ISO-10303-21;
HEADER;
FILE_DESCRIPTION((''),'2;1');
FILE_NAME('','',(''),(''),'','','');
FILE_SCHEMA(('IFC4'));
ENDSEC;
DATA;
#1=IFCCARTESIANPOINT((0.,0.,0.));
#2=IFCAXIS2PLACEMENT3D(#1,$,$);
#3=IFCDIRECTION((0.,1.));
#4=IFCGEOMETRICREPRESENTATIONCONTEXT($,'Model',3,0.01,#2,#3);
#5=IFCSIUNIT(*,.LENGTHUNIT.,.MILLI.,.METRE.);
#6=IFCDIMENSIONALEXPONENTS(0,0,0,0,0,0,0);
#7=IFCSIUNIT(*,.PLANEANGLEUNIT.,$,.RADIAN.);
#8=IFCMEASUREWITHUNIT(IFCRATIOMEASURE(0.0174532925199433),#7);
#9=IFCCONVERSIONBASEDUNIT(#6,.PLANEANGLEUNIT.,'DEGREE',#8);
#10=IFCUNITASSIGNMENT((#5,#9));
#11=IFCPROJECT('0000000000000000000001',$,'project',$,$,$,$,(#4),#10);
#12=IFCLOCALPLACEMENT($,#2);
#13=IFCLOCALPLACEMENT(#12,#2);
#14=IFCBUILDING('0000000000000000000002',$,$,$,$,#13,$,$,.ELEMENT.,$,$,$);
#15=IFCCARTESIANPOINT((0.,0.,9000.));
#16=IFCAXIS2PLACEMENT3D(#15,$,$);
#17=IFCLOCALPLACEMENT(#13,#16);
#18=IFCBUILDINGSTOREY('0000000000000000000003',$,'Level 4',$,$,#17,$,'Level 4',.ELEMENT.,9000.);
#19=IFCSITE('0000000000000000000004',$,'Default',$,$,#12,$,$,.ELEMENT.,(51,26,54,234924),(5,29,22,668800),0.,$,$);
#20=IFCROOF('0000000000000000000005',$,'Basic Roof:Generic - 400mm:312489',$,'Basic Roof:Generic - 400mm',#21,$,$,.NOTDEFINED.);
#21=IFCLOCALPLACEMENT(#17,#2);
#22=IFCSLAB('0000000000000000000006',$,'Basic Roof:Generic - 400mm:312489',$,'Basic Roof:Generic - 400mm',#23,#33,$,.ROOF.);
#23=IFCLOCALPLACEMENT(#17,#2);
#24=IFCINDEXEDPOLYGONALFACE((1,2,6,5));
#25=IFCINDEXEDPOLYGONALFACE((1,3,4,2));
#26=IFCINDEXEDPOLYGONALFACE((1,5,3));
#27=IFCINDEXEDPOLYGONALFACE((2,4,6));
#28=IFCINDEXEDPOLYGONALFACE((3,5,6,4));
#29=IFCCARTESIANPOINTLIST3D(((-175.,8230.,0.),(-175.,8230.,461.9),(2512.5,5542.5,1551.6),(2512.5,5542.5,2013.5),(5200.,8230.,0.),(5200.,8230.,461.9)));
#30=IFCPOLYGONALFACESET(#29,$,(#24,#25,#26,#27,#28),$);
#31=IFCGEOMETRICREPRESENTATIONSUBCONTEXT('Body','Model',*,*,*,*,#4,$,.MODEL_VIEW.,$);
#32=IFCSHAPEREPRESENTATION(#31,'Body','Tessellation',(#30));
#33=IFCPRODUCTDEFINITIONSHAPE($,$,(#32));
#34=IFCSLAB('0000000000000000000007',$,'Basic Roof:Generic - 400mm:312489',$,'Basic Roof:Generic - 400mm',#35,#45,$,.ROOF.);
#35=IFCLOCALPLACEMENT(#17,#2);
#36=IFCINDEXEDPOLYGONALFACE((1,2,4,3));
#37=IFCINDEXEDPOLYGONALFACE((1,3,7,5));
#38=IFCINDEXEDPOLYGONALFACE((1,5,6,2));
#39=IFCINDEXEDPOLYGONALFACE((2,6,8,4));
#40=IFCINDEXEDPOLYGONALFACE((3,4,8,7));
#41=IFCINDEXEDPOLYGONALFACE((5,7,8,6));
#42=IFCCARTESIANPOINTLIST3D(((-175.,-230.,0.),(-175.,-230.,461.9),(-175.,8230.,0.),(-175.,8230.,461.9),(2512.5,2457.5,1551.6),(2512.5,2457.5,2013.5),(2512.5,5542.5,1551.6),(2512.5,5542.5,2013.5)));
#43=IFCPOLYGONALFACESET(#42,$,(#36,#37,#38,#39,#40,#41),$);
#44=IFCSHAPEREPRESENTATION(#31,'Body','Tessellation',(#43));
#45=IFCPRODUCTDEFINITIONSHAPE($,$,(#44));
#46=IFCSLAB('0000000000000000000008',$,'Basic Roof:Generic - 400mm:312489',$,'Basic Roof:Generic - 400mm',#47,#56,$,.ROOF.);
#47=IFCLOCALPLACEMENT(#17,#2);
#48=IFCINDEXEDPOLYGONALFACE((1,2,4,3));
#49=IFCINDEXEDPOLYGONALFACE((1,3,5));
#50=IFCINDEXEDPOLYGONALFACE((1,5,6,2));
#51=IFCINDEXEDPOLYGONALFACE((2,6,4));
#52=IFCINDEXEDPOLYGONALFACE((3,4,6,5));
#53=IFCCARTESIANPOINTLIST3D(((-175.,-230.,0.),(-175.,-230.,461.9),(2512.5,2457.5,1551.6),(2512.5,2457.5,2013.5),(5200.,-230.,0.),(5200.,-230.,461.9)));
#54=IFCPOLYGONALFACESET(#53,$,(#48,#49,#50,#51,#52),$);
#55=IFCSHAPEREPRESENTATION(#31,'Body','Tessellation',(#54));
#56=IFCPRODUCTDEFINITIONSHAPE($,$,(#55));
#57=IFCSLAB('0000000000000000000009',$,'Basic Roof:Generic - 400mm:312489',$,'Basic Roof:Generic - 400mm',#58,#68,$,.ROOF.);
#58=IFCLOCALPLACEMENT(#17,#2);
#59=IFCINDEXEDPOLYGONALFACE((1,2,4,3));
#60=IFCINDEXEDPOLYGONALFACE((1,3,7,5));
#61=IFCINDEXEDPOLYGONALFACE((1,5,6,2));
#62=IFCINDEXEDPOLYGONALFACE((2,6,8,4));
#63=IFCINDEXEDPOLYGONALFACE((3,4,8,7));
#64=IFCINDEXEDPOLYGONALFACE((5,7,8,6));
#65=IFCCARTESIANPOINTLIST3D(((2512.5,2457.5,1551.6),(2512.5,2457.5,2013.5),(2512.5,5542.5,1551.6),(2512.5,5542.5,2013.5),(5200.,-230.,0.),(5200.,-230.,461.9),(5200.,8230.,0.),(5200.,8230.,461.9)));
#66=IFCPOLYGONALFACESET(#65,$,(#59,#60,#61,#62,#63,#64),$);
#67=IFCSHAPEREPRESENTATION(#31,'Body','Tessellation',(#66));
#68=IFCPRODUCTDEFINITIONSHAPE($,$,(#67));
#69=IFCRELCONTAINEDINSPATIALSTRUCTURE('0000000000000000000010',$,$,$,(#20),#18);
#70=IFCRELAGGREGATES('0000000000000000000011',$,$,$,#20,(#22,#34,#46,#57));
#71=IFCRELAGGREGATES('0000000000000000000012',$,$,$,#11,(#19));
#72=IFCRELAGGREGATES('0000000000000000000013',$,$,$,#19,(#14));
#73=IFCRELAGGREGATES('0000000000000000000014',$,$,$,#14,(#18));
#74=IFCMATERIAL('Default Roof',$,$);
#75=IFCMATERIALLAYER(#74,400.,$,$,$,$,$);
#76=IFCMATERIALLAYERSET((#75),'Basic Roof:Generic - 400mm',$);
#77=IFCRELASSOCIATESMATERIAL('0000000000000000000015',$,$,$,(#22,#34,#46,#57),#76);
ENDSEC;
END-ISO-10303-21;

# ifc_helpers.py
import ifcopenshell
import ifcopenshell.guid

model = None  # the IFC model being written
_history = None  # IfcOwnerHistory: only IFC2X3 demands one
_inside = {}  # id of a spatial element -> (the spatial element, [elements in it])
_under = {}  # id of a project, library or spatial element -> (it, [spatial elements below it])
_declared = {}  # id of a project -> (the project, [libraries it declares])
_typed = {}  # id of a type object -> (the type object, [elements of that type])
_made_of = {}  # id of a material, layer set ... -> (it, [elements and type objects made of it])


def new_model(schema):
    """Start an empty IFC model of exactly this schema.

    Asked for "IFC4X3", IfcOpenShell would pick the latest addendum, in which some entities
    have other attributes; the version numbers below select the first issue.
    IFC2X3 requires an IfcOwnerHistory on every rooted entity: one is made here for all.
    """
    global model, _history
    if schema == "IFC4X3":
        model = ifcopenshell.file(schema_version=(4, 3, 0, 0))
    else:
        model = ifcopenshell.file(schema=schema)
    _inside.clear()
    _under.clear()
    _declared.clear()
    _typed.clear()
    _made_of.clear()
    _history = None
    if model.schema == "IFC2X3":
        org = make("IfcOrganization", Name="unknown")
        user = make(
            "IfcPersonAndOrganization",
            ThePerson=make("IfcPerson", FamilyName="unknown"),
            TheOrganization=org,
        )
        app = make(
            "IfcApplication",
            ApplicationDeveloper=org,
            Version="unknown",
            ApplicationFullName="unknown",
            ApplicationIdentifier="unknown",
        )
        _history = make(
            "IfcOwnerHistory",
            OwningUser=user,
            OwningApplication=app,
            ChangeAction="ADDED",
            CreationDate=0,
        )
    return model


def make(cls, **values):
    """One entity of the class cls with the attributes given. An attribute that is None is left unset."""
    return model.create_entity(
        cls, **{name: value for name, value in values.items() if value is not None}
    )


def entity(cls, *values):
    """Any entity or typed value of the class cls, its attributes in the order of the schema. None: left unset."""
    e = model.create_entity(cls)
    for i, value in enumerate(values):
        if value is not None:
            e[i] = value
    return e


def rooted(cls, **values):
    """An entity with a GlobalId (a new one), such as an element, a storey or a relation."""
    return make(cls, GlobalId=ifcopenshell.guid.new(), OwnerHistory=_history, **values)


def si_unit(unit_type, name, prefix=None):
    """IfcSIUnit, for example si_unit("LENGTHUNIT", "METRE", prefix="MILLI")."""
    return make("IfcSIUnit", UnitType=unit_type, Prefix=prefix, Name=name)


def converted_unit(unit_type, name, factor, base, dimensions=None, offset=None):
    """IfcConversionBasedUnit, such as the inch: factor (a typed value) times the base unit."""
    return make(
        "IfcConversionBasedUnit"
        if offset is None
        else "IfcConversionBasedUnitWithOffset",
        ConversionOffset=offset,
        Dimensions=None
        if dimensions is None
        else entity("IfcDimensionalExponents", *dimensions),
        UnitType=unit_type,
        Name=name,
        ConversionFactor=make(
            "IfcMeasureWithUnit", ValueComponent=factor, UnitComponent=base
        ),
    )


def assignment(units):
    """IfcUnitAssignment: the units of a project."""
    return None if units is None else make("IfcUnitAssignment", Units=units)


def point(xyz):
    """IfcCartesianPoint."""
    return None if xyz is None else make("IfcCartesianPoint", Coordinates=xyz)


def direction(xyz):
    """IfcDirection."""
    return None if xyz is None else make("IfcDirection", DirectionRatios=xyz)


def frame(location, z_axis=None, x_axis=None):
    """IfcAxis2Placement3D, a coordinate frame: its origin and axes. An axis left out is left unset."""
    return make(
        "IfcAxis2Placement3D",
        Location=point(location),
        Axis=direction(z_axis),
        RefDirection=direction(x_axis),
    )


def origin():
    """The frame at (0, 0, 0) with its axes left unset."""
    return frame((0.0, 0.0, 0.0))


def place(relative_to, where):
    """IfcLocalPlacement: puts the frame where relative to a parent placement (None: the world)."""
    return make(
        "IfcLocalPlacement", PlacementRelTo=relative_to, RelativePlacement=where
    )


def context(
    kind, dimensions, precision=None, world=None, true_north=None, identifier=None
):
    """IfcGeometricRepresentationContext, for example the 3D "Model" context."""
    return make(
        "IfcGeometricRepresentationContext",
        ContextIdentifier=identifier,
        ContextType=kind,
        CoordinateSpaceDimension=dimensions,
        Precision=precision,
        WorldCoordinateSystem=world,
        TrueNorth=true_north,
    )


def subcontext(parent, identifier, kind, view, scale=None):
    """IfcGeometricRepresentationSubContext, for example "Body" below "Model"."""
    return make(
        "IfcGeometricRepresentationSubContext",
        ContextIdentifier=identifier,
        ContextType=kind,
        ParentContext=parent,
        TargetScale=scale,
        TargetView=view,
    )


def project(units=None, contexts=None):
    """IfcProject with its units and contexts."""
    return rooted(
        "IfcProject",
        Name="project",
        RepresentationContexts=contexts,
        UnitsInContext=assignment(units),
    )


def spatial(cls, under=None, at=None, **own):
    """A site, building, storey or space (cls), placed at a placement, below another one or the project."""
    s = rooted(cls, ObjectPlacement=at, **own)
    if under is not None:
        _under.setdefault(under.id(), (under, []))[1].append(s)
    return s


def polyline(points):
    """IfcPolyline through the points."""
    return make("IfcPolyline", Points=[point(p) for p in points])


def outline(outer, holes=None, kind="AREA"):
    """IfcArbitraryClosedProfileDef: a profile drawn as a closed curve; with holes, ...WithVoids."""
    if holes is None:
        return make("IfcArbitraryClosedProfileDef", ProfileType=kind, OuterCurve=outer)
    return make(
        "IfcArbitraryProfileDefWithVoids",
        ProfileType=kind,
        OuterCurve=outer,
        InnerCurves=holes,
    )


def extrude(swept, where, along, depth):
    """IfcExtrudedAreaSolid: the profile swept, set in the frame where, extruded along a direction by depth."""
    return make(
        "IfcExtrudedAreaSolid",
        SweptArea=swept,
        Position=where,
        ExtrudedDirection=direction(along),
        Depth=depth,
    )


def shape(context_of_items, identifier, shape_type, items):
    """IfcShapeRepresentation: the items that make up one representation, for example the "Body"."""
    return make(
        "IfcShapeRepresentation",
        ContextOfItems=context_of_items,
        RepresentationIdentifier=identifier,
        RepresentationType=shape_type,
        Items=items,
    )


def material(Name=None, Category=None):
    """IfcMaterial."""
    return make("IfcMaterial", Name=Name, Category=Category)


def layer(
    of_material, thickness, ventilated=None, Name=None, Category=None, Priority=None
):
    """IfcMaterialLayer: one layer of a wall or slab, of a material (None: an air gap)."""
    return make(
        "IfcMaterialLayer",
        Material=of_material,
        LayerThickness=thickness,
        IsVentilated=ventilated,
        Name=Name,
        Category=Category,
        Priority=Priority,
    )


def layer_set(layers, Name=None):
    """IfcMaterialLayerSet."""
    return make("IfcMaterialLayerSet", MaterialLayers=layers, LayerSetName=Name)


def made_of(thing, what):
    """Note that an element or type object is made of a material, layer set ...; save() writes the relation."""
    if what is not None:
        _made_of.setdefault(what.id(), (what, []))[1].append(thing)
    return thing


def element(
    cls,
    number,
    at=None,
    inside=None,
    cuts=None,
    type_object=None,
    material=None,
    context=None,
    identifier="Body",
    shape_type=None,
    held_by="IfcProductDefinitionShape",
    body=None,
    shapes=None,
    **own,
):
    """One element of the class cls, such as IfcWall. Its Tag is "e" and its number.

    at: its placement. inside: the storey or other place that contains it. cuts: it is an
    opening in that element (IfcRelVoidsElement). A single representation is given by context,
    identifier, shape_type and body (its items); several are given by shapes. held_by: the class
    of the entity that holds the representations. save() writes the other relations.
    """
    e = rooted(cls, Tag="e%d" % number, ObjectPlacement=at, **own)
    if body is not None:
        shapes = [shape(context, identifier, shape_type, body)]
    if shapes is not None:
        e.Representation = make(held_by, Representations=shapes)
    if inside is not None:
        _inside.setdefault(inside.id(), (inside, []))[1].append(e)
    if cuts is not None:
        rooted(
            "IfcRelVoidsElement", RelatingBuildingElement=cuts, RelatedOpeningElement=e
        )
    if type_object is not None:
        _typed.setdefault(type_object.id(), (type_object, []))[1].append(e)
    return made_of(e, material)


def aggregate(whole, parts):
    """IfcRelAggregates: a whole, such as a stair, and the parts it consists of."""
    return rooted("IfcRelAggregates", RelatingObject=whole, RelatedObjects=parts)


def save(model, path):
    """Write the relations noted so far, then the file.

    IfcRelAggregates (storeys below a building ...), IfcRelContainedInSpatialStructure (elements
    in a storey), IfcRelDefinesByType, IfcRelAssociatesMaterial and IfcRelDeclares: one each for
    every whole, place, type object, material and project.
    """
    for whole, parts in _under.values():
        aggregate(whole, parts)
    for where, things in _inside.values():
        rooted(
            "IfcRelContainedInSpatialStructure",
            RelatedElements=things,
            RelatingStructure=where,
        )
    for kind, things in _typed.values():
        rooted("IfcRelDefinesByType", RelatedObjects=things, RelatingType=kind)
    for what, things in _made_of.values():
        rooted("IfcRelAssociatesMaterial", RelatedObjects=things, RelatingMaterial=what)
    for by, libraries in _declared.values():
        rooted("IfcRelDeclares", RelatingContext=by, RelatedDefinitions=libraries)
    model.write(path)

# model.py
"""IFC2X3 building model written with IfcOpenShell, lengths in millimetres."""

from ifc_helpers import new_model, entity, si_unit, converted_unit, direction, frame, origin, place, context, subcontext, project, spatial, polyline, outline, extrude, material, layer, layer_set, element, aggregate, save


model = new_model("IFC2X3")

# Units and contexts
model_context = context("Model", 3, precision=0.01, world=origin(), true_north=direction((0.0, 1.0)))
body_context = subcontext(model_context, "Body", "Model", "MODEL_VIEW")
ifc_project = project(units=[si_unit("LENGTHUNIT", "METRE", prefix="MILLI"), converted_unit("PLANEANGLEUNIT", "DEGREE", entity("IfcRatioMeasure", 0.0174532925199433), si_unit("PLANEANGLEUNIT", "RADIAN"), dimensions=[0, 0, 0, 0, 0, 0, 0])], contexts=[model_context])

# Site, building, storey
site_placement = place(None, origin())
site = spatial("IfcSite", under=ifc_project, at=site_placement, Name="Default", CompositionType="ELEMENT", RefLatitude=(51, 26, 54, 234924), RefLongitude=(5, 29, 22, 668800), RefElevation=0.0)
building_placement = place(site_placement, origin())
building = spatial("IfcBuilding", under=site, at=building_placement, CompositionType="ELEMENT")
storey_placement = place(building_placement, frame((0.0, 0.0, 9000.0)))
storey = spatial("IfcBuildingStorey", under=building, at=storey_placement, Name="Level 4", LongName="Level 4", CompositionType="ELEMENT", Elevation=9000.0)

# Roof, slabs
roof_placement = place(storey_placement, frame((-175.0, -230.0, 0.0)))
roof = element("IfcRoof", 1, at=roof_placement, inside=storey, Name="Basic Roof:Generic - 400mm:312489", ObjectType="Basic Roof:Generic - 400mm", ShapeType="NOTDEFINED")
ifc_material = material(Name="Default Roof")
ifc_layer = layer(ifc_material, 400.0)
ifc_layer_set = layer_set([ifc_layer], Name="Basic Roof:Generic - 400mm")
slab_1_placement = place(roof_placement, origin())
slab_1 = element("IfcSlab", 2, at=slab_1_placement, material=ifc_layer_set, Name="Basic Roof:Generic - 400mm:312489", ObjectType="Basic Roof:Generic - 400mm", PredefinedType="ROOF", context=body_context, shape_type="SweptSolid", body=[
    extrude(outline(polyline([(2687.5, 1551.6), (-2687.5, 1551.6), (0.0, -1551.6), (2687.5, 1551.6)])), frame((2687.5, 7116.3, 775.8), z_axis=(0.0, 0.5, 0.866025), x_axis=(1.0, 0.0, 0.0)), (0.0, -0.5, 0.866025), 461.9),
])
slab_2_placement = place(roof_placement, origin())
slab_2 = element("IfcSlab", 3, at=slab_2_placement, material=ifc_layer_set, Name="Basic Roof:Generic - 400mm:312489", ObjectType="Basic Roof:Generic - 400mm", PredefinedType="ROOF", context=body_context, shape_type="SweptSolid", body=[
    extrude(outline(polyline([(-1551.6, 4230.0), (-1551.6, -4230.0), (1551.6, -1542.5), (1551.6, 1542.5), (-1551.6, 4230.0)])), frame((1343.8, 4230.0, 775.8), z_axis=(-0.5, 0.0, 0.866025), x_axis=(0.866025, 0.0, 0.5)), (0.5, 0.0, 0.866025), 461.9),
])
slab_3_placement = place(roof_placement, origin())
slab_3 = element("IfcSlab", 4, at=slab_3_placement, material=ifc_layer_set, Name="Basic Roof:Generic - 400mm:312489", ObjectType="Basic Roof:Generic - 400mm", PredefinedType="ROOF", context=body_context, shape_type="SweptSolid", body=[
    extrude(outline(polyline([(-2687.5, -1551.6), (2687.5, -1551.6), (0.0, 1551.6), (-2687.5, -1551.6)])), frame((2687.5, 1343.8, 775.8), z_axis=(0.0, -0.5, 0.866025), x_axis=(1.0, 0.0, 0.0)), (0.0, 0.5, 0.866025), 461.9),
])
slab_4_placement = place(roof_placement, origin())
slab_4 = element("IfcSlab", 5, at=slab_4_placement, material=ifc_layer_set, Name="Basic Roof:Generic - 400mm:312489", ObjectType="Basic Roof:Generic - 400mm", PredefinedType="ROOF", context=body_context, shape_type="SweptSolid", body=[
    extrude(outline(polyline([(-1551.6, 1542.5), (-1551.6, -1542.5), (1551.6, -4230.0), (1551.6, 4230.0), (-1551.6, 1542.5)])), frame((4031.2, 4230.0, 775.8), z_axis=(0.5, 0.0, 0.866025), x_axis=(0.866025, 0.0, -0.5)), (-0.5, 0.0, 0.866025), 461.9),
])
aggregate(roof, [slab_1, slab_2, slab_3, slab_4])

save(model, "model.ifc")
